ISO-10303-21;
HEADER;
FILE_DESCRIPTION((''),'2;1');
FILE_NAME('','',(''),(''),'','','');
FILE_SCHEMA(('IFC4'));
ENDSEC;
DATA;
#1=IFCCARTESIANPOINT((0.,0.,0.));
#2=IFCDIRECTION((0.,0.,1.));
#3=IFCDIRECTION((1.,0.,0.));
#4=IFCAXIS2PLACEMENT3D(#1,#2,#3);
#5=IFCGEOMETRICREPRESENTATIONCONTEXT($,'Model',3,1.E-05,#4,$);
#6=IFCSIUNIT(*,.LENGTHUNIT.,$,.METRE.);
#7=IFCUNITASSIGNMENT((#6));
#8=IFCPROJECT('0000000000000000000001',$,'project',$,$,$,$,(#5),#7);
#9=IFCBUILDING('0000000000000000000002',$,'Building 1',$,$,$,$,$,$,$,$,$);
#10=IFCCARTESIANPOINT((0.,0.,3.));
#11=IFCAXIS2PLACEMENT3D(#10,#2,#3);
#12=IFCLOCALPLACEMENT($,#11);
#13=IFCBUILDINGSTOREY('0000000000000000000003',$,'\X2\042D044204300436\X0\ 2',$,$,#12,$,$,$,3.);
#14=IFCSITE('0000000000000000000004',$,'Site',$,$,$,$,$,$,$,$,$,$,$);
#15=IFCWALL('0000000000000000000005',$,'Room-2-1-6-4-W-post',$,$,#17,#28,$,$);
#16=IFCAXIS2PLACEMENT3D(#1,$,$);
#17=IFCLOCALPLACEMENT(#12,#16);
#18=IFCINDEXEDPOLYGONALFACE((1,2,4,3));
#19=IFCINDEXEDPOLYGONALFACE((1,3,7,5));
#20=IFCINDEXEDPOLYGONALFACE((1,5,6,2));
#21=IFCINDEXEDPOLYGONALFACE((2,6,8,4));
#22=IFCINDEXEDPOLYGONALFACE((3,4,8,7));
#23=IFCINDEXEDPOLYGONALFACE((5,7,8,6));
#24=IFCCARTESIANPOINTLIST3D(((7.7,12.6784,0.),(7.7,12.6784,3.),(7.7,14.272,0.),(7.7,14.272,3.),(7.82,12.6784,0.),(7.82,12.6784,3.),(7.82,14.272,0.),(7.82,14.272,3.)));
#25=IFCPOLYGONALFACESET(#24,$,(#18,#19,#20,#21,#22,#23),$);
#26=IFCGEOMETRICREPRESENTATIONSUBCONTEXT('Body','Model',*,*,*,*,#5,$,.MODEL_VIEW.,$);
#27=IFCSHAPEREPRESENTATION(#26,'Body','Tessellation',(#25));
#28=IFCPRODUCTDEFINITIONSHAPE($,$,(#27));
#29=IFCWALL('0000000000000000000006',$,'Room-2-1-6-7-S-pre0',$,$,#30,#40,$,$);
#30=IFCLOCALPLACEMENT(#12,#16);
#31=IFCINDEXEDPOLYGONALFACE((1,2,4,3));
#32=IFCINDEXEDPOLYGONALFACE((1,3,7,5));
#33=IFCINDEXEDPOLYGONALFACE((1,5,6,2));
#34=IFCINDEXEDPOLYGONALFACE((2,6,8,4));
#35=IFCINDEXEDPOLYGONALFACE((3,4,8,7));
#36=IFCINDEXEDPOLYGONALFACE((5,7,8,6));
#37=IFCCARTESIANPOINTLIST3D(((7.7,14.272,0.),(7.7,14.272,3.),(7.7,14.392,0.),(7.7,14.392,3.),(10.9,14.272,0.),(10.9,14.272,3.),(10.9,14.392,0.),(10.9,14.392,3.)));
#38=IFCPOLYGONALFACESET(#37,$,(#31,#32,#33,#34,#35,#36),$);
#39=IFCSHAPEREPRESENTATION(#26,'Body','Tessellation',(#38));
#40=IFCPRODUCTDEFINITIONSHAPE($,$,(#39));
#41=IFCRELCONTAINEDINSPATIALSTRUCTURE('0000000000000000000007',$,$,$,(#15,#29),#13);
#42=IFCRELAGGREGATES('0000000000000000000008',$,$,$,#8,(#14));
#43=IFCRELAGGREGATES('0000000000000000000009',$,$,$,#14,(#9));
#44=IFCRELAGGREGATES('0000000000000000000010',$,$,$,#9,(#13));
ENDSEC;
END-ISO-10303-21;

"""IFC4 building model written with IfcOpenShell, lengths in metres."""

from ifc_helpers import new_model, si_unit, frame, origin_with_axes, place, context, subcontext, project, spatial, indexed_curve, outline, extrude, element, save


model = new_model("IFC4")

# Units and contexts
model_context = context("Model", 3, precision=1e-05, world=origin_with_axes())
body_context = subcontext(model_context, "Body", "Model", "MODEL_VIEW")
ifc_project = project(units=[si_unit("LENGTHUNIT", "METRE")], contexts=[model_context])

# Site, building, storey
site = spatial("IfcSite", under=ifc_project, Name="Site")
building = spatial("IfcBuilding", under=site, Name="Building 1")
storey_placement = place(None, frame((0.0, 0.0, 3.0), z_axis=(0.0, 0.0, 1.0), x_axis=(1.0, 0.0, 0.0)))
storey = spatial("IfcBuildingStorey", under=building, at=storey_placement, Name="Этаж 2", Elevation=3.0)

# Walls
wall_1_placement = place(storey_placement, frame((7.7, 14.272, 0.0), z_axis=(0.0, 0.0, 1.0), x_axis=(0.0, -1.0, 0.0)))
element("IfcWall", 1, at=wall_1_placement, inside=storey, Name="Room-2-1-6-4-W-post", context=body_context, shape_type="SweptSolid", body=[
    extrude(outline(indexed_curve([(0.0, 0.0), (0.0, 0.12), (1.5936, 0.12), (1.5936, 0.0), (0.0, 0.0)], self_intersect=False)), origin_with_axes(), (0.0, 0.0, 1.0), 3.0),
])
wall_2_placement = place(storey_placement, frame((7.7, 14.272, 0.0), z_axis=(0.0, 0.0, 1.0), x_axis=(1.0, 0.0, 0.0)))
element("IfcWall", 2, at=wall_2_placement, inside=storey, Name="Room-2-1-6-7-S-pre0", context=body_context, shape_type="SweptSolid", body=[
    extrude(outline(indexed_curve([(0.0, 0.0), (0.0, 0.12), (3.2, 0.12), (3.2, 0.0), (0.0, 0.0)], self_intersect=False)), origin_with_axes(), (0.0, 0.0, 1.0), 3.0),
])

save(model, "model.ifc")
